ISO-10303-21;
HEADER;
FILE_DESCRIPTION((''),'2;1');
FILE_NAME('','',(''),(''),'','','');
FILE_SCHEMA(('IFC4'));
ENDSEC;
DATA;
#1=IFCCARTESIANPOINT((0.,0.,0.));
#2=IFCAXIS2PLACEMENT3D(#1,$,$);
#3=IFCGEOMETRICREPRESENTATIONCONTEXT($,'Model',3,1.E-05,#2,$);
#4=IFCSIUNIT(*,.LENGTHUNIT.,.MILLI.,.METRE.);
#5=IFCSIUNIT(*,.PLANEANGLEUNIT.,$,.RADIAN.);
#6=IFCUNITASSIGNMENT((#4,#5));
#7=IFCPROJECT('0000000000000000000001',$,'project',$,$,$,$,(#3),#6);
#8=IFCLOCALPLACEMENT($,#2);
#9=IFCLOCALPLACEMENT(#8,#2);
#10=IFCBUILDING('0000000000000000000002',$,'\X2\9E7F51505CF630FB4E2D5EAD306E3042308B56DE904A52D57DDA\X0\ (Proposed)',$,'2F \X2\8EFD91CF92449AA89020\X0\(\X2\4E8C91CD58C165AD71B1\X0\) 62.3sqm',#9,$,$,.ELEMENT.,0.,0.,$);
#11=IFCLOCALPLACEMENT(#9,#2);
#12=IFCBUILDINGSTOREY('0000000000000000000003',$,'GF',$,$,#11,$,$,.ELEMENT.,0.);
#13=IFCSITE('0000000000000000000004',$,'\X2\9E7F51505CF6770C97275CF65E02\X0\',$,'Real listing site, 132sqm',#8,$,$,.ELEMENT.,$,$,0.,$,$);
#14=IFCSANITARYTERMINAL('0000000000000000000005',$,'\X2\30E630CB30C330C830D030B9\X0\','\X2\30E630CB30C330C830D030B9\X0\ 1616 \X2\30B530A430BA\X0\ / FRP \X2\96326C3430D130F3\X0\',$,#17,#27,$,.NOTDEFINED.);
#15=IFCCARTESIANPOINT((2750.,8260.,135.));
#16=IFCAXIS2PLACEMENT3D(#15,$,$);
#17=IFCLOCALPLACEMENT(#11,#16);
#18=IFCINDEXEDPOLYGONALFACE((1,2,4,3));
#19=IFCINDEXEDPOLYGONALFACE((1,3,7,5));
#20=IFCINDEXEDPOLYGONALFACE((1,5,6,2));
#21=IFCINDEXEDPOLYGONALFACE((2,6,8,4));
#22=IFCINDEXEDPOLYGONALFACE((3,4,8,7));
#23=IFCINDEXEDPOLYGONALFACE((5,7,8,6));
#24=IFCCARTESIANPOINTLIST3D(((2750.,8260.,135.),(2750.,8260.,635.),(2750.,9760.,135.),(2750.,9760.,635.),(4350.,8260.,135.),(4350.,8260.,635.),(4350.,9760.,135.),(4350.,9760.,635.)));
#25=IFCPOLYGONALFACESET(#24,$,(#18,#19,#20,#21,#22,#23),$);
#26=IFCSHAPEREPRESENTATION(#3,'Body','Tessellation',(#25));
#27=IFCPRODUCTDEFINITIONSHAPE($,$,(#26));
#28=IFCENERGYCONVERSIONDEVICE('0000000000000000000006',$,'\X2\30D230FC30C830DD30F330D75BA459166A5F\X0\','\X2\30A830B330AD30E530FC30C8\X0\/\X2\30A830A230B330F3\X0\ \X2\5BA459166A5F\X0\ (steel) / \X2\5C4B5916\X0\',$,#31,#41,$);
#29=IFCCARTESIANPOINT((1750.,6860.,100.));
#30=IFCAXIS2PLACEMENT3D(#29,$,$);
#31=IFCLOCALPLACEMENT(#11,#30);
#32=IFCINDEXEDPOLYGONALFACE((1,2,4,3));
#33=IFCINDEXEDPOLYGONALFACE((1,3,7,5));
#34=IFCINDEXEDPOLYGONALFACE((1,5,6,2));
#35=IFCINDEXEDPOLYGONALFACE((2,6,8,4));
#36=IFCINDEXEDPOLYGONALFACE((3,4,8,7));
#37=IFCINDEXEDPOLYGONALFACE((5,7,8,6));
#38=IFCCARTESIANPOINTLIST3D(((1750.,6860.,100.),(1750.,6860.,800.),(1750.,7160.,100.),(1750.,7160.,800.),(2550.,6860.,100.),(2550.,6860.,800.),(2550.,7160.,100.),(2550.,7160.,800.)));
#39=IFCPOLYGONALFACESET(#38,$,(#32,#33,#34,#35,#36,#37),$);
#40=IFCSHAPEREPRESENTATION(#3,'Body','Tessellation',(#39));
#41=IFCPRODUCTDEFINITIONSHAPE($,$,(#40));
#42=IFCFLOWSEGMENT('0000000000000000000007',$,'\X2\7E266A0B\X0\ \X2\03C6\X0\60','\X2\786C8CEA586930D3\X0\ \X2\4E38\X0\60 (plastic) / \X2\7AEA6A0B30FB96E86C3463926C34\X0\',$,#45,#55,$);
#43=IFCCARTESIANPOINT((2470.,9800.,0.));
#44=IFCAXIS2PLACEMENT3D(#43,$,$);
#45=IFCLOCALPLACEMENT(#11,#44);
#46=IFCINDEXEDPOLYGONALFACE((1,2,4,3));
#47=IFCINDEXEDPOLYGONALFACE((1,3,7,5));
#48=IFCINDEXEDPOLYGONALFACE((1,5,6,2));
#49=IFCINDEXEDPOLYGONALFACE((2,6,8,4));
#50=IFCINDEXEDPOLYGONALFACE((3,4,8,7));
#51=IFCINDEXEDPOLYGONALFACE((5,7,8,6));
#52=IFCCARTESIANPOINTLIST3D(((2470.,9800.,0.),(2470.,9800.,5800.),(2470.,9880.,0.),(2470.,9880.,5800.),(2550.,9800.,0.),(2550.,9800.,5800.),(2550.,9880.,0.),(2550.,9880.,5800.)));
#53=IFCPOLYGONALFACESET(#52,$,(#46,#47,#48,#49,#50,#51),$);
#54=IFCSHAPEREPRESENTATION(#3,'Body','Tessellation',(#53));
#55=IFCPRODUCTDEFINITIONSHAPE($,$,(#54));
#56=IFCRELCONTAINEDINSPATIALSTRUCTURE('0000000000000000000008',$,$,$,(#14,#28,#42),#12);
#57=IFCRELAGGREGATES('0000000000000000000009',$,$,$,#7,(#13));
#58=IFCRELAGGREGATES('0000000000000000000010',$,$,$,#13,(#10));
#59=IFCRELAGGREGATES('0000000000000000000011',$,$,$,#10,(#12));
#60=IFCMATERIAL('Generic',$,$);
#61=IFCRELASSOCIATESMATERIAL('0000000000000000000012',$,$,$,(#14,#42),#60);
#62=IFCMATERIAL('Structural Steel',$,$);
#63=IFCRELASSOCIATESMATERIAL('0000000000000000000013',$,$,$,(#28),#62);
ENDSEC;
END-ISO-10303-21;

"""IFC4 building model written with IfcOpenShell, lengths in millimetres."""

from ifc_helpers import new_model, si_unit, frame, frame_2d, origin, place, context, project, spatial, rectangle, extrude, material, element, save


model = new_model("IFC4")

# Units and contexts
model_context = context("Model", 3, precision=1e-05, world=origin())
ifc_project = project(units=[si_unit("LENGTHUNIT", "METRE", prefix="MILLI"), si_unit("PLANEANGLEUNIT", "RADIAN")], contexts=[model_context])

# Site, building, storey
site_placement = place(None, origin())
site = spatial("IfcSite", under=ifc_project, at=site_placement, Name="鹿児島県霧島市", ObjectType="Real listing site, 132sqm", CompositionType="ELEMENT", RefElevation=0.0)
building_placement = place(site_placement, origin())
building = spatial("IfcBuilding", under=site, at=building_placement, Name="鹿児島・中庭のある回遊動線 (Proposed)", ObjectType="2F 軽量鉄骨造(二重壁断熱) 62.3sqm", CompositionType="ELEMENT", ElevationOfRefHeight=0.0, ElevationOfTerrain=0.0)
storey_placement = place(building_placement, origin())
storey = spatial("IfcBuildingStorey", under=building, at=storey_placement, Name="GF", CompositionType="ELEMENT", Elevation=0.0)

# Shared definitions
ifc_material_1 = material(Name="Generic")

# Sanitary terminal
sanitary_terminal_placement = place(storey_placement, frame((2750.0, 8260.0, 135.0)))
element("IfcSanitaryTerminal", 1, at=sanitary_terminal_placement, inside=storey, material=ifc_material_1, Name="ユニットバス", Description="ユニットバス 1616 サイズ / FRP 防水パン", PredefinedType="NOTDEFINED", context=model_context, shape_type="SweptSolid", body=[
    extrude(rectangle(XDim=1600.0, YDim=1500.0, at=frame_2d((800.0, 750.0))), frame((2750.0, 8260.0, 135.0)), (0.0, 0.0, 1.0), 500.0),
])

# Energy conversion device
ifc_material_2 = material(Name="Structural Steel")
energy_conversion_device_placement = place(storey_placement, frame((1750.0, 6860.0, 100.0)))
element("IfcEnergyConversionDevice", 2, at=energy_conversion_device_placement, inside=storey, material=ifc_material_2, Name="ヒートポンプ室外機", Description="エコキュート/エアコン 室外機 (steel) / 屋外", context=model_context, shape_type="SweptSolid", body=[
    extrude(rectangle(XDim=800.0, YDim=300.0, at=frame_2d((400.0, 150.0))), frame((1750.0, 6860.0, 100.0)), (0.0, 0.0, 1.0), 700.0),
])

# Flow segment
flow_segment_placement = place(storey_placement, frame((2470.0, 9800.0, 0.0)))
element("IfcFlowSegment", 3, at=flow_segment_placement, inside=storey, material=ifc_material_1, Name="縦樋 φ60", Description="硬質塩ビ 丸60 (plastic) / 竪樋・雨水排水", context=model_context, shape_type="SweptSolid", body=[
    extrude(rectangle(XDim=80.0, YDim=80.0, at=frame_2d((40.0, 40.0))), frame((2470.0, 9800.0, 0.0)), (0.0, 0.0, 1.0), 5800.0),
])

save(model, "model.ifc")
